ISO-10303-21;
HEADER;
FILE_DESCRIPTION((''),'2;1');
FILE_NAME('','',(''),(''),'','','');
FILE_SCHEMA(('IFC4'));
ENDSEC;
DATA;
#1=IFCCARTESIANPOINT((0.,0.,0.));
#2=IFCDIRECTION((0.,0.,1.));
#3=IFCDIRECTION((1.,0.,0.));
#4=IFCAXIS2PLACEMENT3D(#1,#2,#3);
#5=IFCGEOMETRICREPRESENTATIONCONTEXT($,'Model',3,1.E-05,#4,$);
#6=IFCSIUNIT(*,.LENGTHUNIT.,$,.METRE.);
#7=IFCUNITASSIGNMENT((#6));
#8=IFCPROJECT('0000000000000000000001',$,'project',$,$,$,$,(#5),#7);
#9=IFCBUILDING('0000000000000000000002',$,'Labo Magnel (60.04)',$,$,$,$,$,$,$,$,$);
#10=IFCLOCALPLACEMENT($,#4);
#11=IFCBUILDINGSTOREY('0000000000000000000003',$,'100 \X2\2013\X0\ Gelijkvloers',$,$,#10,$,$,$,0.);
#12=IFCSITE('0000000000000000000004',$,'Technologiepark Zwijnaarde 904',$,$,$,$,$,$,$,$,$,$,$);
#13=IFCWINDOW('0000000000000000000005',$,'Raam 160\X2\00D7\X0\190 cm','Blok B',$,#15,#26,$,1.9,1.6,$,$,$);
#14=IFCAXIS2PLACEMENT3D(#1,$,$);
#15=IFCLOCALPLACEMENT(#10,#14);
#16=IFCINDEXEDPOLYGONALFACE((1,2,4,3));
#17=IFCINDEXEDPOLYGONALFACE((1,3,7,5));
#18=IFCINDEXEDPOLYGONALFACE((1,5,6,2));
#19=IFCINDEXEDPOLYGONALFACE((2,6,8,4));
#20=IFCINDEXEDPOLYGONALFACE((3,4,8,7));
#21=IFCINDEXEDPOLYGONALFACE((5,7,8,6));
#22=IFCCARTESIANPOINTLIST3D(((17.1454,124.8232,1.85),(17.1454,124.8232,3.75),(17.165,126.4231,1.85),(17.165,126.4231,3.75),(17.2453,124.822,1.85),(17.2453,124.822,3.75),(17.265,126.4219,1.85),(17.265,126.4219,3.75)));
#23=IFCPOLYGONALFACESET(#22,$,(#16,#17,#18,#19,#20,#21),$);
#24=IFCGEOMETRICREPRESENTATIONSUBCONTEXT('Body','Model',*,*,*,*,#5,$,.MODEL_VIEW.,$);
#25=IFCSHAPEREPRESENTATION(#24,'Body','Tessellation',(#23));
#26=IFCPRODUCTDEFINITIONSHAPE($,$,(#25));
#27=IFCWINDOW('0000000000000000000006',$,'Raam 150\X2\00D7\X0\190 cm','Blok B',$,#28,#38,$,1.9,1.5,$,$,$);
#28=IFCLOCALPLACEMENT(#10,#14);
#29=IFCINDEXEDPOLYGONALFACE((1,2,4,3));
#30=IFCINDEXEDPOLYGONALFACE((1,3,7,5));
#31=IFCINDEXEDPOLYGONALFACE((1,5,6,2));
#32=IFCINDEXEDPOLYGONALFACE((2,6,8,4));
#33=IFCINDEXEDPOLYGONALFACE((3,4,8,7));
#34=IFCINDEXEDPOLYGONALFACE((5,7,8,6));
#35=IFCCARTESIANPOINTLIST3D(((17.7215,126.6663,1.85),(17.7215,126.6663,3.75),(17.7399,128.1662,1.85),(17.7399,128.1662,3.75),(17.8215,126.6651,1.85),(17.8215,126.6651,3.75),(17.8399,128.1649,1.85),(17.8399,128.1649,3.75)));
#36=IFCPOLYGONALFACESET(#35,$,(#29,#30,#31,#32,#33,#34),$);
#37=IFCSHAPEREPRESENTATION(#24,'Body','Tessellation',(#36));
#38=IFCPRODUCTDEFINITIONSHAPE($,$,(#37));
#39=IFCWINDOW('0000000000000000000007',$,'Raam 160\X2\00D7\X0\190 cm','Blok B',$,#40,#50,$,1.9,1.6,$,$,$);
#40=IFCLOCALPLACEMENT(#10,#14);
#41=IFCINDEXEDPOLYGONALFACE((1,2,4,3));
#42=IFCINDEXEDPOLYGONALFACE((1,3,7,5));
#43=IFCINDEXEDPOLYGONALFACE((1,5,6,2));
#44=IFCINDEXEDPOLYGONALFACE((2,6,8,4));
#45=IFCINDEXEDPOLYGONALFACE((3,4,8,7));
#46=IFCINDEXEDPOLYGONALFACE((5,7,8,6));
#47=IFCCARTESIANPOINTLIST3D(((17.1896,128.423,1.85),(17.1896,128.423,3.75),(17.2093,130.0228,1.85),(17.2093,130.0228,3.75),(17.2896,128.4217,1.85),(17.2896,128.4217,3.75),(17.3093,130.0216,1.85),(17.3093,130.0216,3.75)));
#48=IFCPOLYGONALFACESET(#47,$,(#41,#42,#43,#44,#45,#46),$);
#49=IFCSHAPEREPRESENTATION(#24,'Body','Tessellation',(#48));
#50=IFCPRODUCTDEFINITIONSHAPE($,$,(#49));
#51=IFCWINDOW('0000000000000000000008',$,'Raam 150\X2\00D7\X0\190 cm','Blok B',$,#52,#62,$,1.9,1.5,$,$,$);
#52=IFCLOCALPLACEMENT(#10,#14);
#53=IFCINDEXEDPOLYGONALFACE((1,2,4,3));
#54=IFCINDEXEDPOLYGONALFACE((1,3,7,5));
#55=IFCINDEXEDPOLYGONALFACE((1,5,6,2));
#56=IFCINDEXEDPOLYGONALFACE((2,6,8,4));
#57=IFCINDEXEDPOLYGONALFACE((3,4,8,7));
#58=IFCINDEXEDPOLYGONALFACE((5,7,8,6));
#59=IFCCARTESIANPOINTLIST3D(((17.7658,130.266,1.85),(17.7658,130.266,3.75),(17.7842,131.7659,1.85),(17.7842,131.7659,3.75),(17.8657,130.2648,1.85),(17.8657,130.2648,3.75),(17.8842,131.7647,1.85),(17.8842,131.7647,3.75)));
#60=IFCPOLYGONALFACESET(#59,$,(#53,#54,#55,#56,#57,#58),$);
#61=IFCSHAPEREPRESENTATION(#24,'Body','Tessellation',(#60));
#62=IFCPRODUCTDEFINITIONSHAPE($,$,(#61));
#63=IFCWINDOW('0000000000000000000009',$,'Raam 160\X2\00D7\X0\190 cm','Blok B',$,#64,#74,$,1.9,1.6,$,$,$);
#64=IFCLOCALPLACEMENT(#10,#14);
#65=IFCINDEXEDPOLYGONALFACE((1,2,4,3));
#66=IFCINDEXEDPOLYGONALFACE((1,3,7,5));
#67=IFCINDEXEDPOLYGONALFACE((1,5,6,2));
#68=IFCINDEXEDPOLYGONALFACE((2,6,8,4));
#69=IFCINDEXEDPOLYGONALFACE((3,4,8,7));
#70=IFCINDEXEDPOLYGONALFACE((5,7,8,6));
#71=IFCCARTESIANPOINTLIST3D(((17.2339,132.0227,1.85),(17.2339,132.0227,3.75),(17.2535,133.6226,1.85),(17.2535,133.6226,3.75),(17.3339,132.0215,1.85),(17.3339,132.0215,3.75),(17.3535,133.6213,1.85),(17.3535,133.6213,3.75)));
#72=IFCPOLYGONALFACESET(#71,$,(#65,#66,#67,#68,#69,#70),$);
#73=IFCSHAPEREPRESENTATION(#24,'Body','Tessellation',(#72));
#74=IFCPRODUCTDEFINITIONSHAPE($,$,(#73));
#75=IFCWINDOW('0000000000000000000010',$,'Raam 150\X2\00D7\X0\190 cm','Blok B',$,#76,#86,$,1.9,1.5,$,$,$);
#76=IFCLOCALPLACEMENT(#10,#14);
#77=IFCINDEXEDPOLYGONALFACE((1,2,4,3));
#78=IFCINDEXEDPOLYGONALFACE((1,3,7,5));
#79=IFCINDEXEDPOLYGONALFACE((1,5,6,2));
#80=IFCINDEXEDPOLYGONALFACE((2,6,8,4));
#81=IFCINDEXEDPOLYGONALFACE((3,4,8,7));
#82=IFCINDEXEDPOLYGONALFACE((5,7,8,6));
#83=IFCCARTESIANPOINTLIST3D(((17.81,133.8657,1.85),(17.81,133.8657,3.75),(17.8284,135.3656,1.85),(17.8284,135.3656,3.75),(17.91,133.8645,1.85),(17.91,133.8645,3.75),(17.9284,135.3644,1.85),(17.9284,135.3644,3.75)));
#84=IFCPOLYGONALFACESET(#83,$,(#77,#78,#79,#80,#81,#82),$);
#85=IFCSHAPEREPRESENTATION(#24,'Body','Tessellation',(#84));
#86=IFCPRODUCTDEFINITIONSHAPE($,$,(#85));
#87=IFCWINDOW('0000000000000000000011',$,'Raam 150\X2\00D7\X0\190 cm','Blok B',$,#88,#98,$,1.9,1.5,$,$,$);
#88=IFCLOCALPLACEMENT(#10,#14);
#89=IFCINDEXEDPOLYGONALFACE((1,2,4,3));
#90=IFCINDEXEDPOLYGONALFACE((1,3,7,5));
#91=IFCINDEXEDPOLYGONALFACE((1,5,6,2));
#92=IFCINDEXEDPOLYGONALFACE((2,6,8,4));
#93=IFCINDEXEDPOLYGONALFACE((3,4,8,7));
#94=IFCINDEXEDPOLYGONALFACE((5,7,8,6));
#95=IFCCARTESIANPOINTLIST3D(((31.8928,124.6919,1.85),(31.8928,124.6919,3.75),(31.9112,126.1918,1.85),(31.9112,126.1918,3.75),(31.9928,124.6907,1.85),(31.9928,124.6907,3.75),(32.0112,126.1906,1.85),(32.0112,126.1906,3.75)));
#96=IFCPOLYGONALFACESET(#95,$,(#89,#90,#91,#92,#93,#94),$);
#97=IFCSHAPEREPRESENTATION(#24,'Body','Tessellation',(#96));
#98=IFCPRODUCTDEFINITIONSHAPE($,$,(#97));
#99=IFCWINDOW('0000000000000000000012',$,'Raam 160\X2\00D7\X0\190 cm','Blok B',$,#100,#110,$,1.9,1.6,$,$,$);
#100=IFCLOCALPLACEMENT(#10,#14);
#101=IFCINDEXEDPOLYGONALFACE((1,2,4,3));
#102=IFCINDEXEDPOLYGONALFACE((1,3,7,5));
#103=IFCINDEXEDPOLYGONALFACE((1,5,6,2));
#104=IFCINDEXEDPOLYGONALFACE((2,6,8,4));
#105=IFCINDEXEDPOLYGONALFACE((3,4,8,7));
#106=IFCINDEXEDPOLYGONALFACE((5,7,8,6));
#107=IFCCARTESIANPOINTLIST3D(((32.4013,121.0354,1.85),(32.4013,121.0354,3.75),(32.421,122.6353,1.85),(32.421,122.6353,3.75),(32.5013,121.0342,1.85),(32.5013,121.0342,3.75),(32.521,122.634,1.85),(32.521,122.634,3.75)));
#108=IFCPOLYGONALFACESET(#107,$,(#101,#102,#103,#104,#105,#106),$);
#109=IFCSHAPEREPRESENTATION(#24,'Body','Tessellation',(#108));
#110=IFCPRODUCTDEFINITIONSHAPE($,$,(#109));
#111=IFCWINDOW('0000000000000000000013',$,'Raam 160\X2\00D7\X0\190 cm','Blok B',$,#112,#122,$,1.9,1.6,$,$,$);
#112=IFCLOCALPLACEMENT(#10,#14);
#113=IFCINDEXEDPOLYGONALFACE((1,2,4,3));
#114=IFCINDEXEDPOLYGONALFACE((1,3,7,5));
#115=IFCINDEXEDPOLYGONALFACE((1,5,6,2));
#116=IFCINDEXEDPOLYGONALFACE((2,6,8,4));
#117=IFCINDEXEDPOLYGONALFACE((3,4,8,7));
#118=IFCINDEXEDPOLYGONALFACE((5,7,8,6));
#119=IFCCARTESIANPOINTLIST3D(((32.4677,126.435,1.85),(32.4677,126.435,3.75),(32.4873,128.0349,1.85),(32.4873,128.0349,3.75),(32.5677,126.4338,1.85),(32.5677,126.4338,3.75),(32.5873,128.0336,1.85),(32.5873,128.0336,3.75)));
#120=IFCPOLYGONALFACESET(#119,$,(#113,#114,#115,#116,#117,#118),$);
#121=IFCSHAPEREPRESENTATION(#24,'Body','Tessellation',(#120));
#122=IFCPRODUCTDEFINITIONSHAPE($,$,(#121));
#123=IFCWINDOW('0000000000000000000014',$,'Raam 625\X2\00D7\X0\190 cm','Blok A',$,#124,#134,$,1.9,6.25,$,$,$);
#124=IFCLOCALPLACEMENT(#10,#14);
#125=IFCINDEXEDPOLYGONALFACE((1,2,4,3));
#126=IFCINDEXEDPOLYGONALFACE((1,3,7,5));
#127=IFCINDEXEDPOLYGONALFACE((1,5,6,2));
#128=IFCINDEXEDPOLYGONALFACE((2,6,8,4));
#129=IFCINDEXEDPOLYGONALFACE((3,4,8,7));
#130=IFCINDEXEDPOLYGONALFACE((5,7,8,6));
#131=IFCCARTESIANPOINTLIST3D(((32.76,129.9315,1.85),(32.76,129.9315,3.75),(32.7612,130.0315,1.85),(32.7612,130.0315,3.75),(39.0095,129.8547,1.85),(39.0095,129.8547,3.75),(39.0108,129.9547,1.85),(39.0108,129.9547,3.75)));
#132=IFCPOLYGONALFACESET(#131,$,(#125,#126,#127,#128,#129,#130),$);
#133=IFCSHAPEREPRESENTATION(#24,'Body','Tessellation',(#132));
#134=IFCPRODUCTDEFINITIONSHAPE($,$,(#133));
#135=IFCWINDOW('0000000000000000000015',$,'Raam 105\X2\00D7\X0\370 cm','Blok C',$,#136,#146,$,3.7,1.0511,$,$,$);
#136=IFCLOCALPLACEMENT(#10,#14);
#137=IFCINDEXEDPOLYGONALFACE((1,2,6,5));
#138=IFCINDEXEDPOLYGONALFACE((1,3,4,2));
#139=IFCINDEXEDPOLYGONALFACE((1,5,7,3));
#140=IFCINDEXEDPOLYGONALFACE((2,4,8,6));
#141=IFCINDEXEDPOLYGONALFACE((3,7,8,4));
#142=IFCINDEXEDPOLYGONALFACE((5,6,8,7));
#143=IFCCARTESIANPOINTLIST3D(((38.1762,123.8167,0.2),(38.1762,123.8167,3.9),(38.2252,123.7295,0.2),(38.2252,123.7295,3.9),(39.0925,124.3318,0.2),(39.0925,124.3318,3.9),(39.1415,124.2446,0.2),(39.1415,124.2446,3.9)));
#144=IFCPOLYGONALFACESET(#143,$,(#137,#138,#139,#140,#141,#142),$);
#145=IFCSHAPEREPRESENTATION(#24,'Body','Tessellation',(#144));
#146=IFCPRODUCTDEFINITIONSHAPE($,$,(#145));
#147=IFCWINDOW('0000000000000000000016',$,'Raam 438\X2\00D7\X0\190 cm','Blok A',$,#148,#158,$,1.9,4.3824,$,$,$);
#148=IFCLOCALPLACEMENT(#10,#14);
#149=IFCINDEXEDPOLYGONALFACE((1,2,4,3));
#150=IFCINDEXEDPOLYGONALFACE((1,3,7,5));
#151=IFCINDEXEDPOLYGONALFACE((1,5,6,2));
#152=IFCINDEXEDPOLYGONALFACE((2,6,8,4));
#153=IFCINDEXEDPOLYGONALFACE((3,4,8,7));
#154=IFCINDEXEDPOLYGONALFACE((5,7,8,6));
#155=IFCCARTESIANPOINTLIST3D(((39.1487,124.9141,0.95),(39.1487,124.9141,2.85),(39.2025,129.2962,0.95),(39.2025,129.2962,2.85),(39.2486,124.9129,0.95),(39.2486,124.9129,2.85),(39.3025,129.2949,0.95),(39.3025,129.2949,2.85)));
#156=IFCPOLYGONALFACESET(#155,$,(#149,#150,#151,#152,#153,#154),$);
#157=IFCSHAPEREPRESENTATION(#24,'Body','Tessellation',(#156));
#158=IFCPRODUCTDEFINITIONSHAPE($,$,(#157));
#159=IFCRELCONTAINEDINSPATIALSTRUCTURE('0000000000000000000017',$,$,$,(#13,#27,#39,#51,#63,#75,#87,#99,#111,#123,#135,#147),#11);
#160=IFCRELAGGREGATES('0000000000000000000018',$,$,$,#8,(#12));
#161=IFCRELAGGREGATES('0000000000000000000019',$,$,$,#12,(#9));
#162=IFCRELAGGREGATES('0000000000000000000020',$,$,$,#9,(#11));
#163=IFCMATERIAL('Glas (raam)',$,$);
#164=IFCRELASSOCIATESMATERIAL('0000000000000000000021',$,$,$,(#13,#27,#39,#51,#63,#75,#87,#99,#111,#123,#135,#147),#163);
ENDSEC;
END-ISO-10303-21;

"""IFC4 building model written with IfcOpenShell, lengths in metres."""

from ifc_helpers import new_model, si_unit, frame, origin, origin_with_axes, place, context, subcontext, project, spatial, polyline, outline, extrude, material, element, save


model = new_model("IFC4")

# Units and contexts
model_context = context("Model", 3, precision=1e-05, world=origin_with_axes())
body_context = subcontext(model_context, "Body", "Model", "MODEL_VIEW")
ifc_project = project(units=[si_unit("LENGTHUNIT", "METRE")], contexts=[model_context])

# Site, building, storey
site = spatial("IfcSite", under=ifc_project, Name="Technologiepark Zwijnaarde 904")
building = spatial("IfcBuilding", under=site, Name="Labo Magnel (60.04)")
storey_placement = place(None, origin_with_axes())
storey = spatial("IfcBuildingStorey", under=building, at=storey_placement, Name="100 – Gelijkvloers", Elevation=0.0)

# Windows
ifc_material_1 = material(Name="Glas (raam)")
window_1_placement = place(storey_placement, frame((17.1954, 124.8226, 1.85), z_axis=(0.0, 0.0, 1.0), x_axis=(0.012293, 0.999924, 0.0)))
element("IfcWindow", 1, at=window_1_placement, inside=storey, material=ifc_material_1, Name="Raam 160×190 cm", Description="Blok B", OverallHeight=1.9, OverallWidth=1.6, context=body_context, shape_type="SweptSolid", body=[
    extrude(outline(polyline([(0.0, -0.05), (1.6, -0.05), (1.6, 0.05), (0.0, 0.05), (0.0, -0.05)])), origin(), (0.0, 0.0, 1.0), 1.9),
])
window_2_placement = place(storey_placement, frame((17.7899, 128.1656, 1.85), z_axis=(0.0, 0.0, 1.0), x_axis=(-0.012293, -0.999924, 0.0)))
element("IfcWindow", 2, at=window_2_placement, inside=storey, material=ifc_material_1, Name="Raam 150×190 cm", Description="Blok B", OverallHeight=1.9, OverallWidth=1.5, context=body_context, shape_type="SweptSolid", body=[
    extrude(outline(polyline([(0.0, -0.05), (1.5, -0.05), (1.5, 0.05), (0.0, 0.05), (0.0, -0.05)])), origin(), (0.0, 0.0, 1.0), 1.9),
])
window_3_placement = place(storey_placement, frame((17.2396, 128.4223, 1.85), z_axis=(0.0, 0.0, 1.0), x_axis=(0.012293, 0.999924, 0.0)))
element("IfcWindow", 3, at=window_3_placement, inside=storey, material=ifc_material_1, Name="Raam 160×190 cm", Description="Blok B", OverallHeight=1.9, OverallWidth=1.6, context=body_context, shape_type="SweptSolid", body=[
    extrude(outline(polyline([(0.0, -0.05), (1.6, -0.05), (1.6, 0.05), (0.0, 0.05), (0.0, -0.05)])), origin(), (0.0, 0.0, 1.0), 1.9),
])
window_4_placement = place(storey_placement, frame((17.8342, 131.7653, 1.85), z_axis=(0.0, 0.0, 1.0), x_axis=(-0.012293, -0.999924, 0.0)))
element("IfcWindow", 4, at=window_4_placement, inside=storey, material=ifc_material_1, Name="Raam 150×190 cm", Description="Blok B", OverallHeight=1.9, OverallWidth=1.5, context=body_context, shape_type="SweptSolid", body=[
    extrude(outline(polyline([(0.0, -0.05), (1.5, -0.05), (1.5, 0.05), (0.0, 0.05), (0.0, -0.05)])), origin(), (0.0, 0.0, 1.0), 1.9),
])
window_5_placement = place(storey_placement, frame((17.2839, 132.0221, 1.85), z_axis=(0.0, 0.0, 1.0), x_axis=(0.012293, 0.999924, 0.0)))
element("IfcWindow", 5, at=window_5_placement, inside=storey, material=ifc_material_1, Name="Raam 160×190 cm", Description="Blok B", OverallHeight=1.9, OverallWidth=1.6, context=body_context, shape_type="SweptSolid", body=[
    extrude(outline(polyline([(0.0, -0.05), (1.6, -0.05), (1.6, 0.05), (0.0, 0.05), (0.0, -0.05)])), origin(), (0.0, 0.0, 1.0), 1.9),
])
window_6_placement = place(storey_placement, frame((17.8784, 135.365, 1.85), z_axis=(0.0, 0.0, 1.0), x_axis=(-0.012293, -0.999924, 0.0)))
element("IfcWindow", 6, at=window_6_placement, inside=storey, material=ifc_material_1, Name="Raam 150×190 cm", Description="Blok B", OverallHeight=1.9, OverallWidth=1.5, context=body_context, shape_type="SweptSolid", body=[
    extrude(outline(polyline([(0.0, -0.05), (1.5, -0.05), (1.5, 0.05), (0.0, 0.05), (0.0, -0.05)])), origin(), (0.0, 0.0, 1.0), 1.9),
])
window_7_placement = place(storey_placement, frame((31.9428, 124.6913, 1.85), z_axis=(0.0, 0.0, 1.0), x_axis=(0.012293, 0.999924, 0.0)))
element("IfcWindow", 7, at=window_7_placement, inside=storey, material=ifc_material_1, Name="Raam 150×190 cm", Description="Blok B", OverallHeight=1.9, OverallWidth=1.5, context=body_context, shape_type="SweptSolid", body=[
    extrude(outline(polyline([(0.0, -0.05), (1.5, -0.05), (1.5, 0.05), (0.0, 0.05), (0.0, -0.05)])), origin(), (0.0, 0.0, 1.0), 1.9),
])
window_8_placement = place(storey_placement, frame((32.4513, 121.0348, 1.85), z_axis=(0.0, 0.0, 1.0), x_axis=(0.012293, 0.999924, 0.0)))
element("IfcWindow", 8, at=window_8_placement, inside=storey, material=ifc_material_1, Name="Raam 160×190 cm", Description="Blok B", OverallHeight=1.9, OverallWidth=1.6, context=body_context, shape_type="SweptSolid", body=[
    extrude(outline(polyline([(0.0, -0.05), (1.6, -0.05), (1.6, 0.05), (0.0, 0.05), (0.0, -0.05)])), origin(), (0.0, 0.0, 1.0), 1.9),
])
window_9_placement = place(storey_placement, frame((32.5177, 126.4344, 1.85), z_axis=(0.0, 0.0, 1.0), x_axis=(0.012293, 0.999924, 0.0)))
element("IfcWindow", 9, at=window_9_placement, inside=storey, material=ifc_material_1, Name="Raam 160×190 cm", Description="Blok B", OverallHeight=1.9, OverallWidth=1.6, context=body_context, shape_type="SweptSolid", body=[
    extrude(outline(polyline([(0.0, -0.05), (1.6, -0.05), (1.6, 0.05), (0.0, 0.05), (0.0, -0.05)])), origin(), (0.0, 0.0, 1.0), 1.9),
])
window_10_placement = place(storey_placement, frame((39.0101, 129.9047, 1.85), z_axis=(0.0, 0.0, 1.0), x_axis=(-0.999924, 0.012293, 0.0)))
element("IfcWindow", 10, at=window_10_placement, inside=storey, material=ifc_material_1, Name="Raam 625×190 cm", Description="Blok A", OverallHeight=1.9, OverallWidth=6.25, context=body_context, shape_type="SweptSolid", body=[
    extrude(outline(polyline([(0.0, -0.05), (6.25, -0.05), (6.25, 0.05), (0.0, 0.05), (0.0, -0.05)])), origin(), (0.0, 0.0, 1.0), 1.9),
])
window_11_placement = place(storey_placement, frame((38.2007, 123.7731, 0.2), z_axis=(0.0, 0.0, 1.0), x_axis=(0.871701, 0.490038, 0.0)))
element("IfcWindow", 11, at=window_11_placement, inside=storey, material=ifc_material_1, Name="Raam 105×370 cm", Description="Blok C", OverallHeight=3.7, OverallWidth=1.0511, context=body_context, shape_type="SweptSolid", body=[
    extrude(outline(polyline([(0.0, -0.05), (1.0511, -0.05), (1.0511, 0.05), (0.0, 0.05), (0.0, -0.05)])), origin(), (0.0, 0.0, 1.0), 3.7),
])
window_12_placement = place(storey_placement, frame((39.2525, 129.2956, 0.95), z_axis=(0.0, 0.0, 1.0), x_axis=(-0.012293, -0.999924, 0.0)))
element("IfcWindow", 12, at=window_12_placement, inside=storey, material=ifc_material_1, Name="Raam 438×190 cm", Description="Blok A", OverallHeight=1.9, OverallWidth=4.3824, context=body_context, shape_type="SweptSolid", body=[
    extrude(outline(polyline([(0.0, -0.05), (4.3824, -0.05), (4.3824, 0.05), (0.0, 0.05), (0.0, -0.05)])), origin(), (0.0, 0.0, 1.0), 1.9),
])

save(model, "model.ifc")
